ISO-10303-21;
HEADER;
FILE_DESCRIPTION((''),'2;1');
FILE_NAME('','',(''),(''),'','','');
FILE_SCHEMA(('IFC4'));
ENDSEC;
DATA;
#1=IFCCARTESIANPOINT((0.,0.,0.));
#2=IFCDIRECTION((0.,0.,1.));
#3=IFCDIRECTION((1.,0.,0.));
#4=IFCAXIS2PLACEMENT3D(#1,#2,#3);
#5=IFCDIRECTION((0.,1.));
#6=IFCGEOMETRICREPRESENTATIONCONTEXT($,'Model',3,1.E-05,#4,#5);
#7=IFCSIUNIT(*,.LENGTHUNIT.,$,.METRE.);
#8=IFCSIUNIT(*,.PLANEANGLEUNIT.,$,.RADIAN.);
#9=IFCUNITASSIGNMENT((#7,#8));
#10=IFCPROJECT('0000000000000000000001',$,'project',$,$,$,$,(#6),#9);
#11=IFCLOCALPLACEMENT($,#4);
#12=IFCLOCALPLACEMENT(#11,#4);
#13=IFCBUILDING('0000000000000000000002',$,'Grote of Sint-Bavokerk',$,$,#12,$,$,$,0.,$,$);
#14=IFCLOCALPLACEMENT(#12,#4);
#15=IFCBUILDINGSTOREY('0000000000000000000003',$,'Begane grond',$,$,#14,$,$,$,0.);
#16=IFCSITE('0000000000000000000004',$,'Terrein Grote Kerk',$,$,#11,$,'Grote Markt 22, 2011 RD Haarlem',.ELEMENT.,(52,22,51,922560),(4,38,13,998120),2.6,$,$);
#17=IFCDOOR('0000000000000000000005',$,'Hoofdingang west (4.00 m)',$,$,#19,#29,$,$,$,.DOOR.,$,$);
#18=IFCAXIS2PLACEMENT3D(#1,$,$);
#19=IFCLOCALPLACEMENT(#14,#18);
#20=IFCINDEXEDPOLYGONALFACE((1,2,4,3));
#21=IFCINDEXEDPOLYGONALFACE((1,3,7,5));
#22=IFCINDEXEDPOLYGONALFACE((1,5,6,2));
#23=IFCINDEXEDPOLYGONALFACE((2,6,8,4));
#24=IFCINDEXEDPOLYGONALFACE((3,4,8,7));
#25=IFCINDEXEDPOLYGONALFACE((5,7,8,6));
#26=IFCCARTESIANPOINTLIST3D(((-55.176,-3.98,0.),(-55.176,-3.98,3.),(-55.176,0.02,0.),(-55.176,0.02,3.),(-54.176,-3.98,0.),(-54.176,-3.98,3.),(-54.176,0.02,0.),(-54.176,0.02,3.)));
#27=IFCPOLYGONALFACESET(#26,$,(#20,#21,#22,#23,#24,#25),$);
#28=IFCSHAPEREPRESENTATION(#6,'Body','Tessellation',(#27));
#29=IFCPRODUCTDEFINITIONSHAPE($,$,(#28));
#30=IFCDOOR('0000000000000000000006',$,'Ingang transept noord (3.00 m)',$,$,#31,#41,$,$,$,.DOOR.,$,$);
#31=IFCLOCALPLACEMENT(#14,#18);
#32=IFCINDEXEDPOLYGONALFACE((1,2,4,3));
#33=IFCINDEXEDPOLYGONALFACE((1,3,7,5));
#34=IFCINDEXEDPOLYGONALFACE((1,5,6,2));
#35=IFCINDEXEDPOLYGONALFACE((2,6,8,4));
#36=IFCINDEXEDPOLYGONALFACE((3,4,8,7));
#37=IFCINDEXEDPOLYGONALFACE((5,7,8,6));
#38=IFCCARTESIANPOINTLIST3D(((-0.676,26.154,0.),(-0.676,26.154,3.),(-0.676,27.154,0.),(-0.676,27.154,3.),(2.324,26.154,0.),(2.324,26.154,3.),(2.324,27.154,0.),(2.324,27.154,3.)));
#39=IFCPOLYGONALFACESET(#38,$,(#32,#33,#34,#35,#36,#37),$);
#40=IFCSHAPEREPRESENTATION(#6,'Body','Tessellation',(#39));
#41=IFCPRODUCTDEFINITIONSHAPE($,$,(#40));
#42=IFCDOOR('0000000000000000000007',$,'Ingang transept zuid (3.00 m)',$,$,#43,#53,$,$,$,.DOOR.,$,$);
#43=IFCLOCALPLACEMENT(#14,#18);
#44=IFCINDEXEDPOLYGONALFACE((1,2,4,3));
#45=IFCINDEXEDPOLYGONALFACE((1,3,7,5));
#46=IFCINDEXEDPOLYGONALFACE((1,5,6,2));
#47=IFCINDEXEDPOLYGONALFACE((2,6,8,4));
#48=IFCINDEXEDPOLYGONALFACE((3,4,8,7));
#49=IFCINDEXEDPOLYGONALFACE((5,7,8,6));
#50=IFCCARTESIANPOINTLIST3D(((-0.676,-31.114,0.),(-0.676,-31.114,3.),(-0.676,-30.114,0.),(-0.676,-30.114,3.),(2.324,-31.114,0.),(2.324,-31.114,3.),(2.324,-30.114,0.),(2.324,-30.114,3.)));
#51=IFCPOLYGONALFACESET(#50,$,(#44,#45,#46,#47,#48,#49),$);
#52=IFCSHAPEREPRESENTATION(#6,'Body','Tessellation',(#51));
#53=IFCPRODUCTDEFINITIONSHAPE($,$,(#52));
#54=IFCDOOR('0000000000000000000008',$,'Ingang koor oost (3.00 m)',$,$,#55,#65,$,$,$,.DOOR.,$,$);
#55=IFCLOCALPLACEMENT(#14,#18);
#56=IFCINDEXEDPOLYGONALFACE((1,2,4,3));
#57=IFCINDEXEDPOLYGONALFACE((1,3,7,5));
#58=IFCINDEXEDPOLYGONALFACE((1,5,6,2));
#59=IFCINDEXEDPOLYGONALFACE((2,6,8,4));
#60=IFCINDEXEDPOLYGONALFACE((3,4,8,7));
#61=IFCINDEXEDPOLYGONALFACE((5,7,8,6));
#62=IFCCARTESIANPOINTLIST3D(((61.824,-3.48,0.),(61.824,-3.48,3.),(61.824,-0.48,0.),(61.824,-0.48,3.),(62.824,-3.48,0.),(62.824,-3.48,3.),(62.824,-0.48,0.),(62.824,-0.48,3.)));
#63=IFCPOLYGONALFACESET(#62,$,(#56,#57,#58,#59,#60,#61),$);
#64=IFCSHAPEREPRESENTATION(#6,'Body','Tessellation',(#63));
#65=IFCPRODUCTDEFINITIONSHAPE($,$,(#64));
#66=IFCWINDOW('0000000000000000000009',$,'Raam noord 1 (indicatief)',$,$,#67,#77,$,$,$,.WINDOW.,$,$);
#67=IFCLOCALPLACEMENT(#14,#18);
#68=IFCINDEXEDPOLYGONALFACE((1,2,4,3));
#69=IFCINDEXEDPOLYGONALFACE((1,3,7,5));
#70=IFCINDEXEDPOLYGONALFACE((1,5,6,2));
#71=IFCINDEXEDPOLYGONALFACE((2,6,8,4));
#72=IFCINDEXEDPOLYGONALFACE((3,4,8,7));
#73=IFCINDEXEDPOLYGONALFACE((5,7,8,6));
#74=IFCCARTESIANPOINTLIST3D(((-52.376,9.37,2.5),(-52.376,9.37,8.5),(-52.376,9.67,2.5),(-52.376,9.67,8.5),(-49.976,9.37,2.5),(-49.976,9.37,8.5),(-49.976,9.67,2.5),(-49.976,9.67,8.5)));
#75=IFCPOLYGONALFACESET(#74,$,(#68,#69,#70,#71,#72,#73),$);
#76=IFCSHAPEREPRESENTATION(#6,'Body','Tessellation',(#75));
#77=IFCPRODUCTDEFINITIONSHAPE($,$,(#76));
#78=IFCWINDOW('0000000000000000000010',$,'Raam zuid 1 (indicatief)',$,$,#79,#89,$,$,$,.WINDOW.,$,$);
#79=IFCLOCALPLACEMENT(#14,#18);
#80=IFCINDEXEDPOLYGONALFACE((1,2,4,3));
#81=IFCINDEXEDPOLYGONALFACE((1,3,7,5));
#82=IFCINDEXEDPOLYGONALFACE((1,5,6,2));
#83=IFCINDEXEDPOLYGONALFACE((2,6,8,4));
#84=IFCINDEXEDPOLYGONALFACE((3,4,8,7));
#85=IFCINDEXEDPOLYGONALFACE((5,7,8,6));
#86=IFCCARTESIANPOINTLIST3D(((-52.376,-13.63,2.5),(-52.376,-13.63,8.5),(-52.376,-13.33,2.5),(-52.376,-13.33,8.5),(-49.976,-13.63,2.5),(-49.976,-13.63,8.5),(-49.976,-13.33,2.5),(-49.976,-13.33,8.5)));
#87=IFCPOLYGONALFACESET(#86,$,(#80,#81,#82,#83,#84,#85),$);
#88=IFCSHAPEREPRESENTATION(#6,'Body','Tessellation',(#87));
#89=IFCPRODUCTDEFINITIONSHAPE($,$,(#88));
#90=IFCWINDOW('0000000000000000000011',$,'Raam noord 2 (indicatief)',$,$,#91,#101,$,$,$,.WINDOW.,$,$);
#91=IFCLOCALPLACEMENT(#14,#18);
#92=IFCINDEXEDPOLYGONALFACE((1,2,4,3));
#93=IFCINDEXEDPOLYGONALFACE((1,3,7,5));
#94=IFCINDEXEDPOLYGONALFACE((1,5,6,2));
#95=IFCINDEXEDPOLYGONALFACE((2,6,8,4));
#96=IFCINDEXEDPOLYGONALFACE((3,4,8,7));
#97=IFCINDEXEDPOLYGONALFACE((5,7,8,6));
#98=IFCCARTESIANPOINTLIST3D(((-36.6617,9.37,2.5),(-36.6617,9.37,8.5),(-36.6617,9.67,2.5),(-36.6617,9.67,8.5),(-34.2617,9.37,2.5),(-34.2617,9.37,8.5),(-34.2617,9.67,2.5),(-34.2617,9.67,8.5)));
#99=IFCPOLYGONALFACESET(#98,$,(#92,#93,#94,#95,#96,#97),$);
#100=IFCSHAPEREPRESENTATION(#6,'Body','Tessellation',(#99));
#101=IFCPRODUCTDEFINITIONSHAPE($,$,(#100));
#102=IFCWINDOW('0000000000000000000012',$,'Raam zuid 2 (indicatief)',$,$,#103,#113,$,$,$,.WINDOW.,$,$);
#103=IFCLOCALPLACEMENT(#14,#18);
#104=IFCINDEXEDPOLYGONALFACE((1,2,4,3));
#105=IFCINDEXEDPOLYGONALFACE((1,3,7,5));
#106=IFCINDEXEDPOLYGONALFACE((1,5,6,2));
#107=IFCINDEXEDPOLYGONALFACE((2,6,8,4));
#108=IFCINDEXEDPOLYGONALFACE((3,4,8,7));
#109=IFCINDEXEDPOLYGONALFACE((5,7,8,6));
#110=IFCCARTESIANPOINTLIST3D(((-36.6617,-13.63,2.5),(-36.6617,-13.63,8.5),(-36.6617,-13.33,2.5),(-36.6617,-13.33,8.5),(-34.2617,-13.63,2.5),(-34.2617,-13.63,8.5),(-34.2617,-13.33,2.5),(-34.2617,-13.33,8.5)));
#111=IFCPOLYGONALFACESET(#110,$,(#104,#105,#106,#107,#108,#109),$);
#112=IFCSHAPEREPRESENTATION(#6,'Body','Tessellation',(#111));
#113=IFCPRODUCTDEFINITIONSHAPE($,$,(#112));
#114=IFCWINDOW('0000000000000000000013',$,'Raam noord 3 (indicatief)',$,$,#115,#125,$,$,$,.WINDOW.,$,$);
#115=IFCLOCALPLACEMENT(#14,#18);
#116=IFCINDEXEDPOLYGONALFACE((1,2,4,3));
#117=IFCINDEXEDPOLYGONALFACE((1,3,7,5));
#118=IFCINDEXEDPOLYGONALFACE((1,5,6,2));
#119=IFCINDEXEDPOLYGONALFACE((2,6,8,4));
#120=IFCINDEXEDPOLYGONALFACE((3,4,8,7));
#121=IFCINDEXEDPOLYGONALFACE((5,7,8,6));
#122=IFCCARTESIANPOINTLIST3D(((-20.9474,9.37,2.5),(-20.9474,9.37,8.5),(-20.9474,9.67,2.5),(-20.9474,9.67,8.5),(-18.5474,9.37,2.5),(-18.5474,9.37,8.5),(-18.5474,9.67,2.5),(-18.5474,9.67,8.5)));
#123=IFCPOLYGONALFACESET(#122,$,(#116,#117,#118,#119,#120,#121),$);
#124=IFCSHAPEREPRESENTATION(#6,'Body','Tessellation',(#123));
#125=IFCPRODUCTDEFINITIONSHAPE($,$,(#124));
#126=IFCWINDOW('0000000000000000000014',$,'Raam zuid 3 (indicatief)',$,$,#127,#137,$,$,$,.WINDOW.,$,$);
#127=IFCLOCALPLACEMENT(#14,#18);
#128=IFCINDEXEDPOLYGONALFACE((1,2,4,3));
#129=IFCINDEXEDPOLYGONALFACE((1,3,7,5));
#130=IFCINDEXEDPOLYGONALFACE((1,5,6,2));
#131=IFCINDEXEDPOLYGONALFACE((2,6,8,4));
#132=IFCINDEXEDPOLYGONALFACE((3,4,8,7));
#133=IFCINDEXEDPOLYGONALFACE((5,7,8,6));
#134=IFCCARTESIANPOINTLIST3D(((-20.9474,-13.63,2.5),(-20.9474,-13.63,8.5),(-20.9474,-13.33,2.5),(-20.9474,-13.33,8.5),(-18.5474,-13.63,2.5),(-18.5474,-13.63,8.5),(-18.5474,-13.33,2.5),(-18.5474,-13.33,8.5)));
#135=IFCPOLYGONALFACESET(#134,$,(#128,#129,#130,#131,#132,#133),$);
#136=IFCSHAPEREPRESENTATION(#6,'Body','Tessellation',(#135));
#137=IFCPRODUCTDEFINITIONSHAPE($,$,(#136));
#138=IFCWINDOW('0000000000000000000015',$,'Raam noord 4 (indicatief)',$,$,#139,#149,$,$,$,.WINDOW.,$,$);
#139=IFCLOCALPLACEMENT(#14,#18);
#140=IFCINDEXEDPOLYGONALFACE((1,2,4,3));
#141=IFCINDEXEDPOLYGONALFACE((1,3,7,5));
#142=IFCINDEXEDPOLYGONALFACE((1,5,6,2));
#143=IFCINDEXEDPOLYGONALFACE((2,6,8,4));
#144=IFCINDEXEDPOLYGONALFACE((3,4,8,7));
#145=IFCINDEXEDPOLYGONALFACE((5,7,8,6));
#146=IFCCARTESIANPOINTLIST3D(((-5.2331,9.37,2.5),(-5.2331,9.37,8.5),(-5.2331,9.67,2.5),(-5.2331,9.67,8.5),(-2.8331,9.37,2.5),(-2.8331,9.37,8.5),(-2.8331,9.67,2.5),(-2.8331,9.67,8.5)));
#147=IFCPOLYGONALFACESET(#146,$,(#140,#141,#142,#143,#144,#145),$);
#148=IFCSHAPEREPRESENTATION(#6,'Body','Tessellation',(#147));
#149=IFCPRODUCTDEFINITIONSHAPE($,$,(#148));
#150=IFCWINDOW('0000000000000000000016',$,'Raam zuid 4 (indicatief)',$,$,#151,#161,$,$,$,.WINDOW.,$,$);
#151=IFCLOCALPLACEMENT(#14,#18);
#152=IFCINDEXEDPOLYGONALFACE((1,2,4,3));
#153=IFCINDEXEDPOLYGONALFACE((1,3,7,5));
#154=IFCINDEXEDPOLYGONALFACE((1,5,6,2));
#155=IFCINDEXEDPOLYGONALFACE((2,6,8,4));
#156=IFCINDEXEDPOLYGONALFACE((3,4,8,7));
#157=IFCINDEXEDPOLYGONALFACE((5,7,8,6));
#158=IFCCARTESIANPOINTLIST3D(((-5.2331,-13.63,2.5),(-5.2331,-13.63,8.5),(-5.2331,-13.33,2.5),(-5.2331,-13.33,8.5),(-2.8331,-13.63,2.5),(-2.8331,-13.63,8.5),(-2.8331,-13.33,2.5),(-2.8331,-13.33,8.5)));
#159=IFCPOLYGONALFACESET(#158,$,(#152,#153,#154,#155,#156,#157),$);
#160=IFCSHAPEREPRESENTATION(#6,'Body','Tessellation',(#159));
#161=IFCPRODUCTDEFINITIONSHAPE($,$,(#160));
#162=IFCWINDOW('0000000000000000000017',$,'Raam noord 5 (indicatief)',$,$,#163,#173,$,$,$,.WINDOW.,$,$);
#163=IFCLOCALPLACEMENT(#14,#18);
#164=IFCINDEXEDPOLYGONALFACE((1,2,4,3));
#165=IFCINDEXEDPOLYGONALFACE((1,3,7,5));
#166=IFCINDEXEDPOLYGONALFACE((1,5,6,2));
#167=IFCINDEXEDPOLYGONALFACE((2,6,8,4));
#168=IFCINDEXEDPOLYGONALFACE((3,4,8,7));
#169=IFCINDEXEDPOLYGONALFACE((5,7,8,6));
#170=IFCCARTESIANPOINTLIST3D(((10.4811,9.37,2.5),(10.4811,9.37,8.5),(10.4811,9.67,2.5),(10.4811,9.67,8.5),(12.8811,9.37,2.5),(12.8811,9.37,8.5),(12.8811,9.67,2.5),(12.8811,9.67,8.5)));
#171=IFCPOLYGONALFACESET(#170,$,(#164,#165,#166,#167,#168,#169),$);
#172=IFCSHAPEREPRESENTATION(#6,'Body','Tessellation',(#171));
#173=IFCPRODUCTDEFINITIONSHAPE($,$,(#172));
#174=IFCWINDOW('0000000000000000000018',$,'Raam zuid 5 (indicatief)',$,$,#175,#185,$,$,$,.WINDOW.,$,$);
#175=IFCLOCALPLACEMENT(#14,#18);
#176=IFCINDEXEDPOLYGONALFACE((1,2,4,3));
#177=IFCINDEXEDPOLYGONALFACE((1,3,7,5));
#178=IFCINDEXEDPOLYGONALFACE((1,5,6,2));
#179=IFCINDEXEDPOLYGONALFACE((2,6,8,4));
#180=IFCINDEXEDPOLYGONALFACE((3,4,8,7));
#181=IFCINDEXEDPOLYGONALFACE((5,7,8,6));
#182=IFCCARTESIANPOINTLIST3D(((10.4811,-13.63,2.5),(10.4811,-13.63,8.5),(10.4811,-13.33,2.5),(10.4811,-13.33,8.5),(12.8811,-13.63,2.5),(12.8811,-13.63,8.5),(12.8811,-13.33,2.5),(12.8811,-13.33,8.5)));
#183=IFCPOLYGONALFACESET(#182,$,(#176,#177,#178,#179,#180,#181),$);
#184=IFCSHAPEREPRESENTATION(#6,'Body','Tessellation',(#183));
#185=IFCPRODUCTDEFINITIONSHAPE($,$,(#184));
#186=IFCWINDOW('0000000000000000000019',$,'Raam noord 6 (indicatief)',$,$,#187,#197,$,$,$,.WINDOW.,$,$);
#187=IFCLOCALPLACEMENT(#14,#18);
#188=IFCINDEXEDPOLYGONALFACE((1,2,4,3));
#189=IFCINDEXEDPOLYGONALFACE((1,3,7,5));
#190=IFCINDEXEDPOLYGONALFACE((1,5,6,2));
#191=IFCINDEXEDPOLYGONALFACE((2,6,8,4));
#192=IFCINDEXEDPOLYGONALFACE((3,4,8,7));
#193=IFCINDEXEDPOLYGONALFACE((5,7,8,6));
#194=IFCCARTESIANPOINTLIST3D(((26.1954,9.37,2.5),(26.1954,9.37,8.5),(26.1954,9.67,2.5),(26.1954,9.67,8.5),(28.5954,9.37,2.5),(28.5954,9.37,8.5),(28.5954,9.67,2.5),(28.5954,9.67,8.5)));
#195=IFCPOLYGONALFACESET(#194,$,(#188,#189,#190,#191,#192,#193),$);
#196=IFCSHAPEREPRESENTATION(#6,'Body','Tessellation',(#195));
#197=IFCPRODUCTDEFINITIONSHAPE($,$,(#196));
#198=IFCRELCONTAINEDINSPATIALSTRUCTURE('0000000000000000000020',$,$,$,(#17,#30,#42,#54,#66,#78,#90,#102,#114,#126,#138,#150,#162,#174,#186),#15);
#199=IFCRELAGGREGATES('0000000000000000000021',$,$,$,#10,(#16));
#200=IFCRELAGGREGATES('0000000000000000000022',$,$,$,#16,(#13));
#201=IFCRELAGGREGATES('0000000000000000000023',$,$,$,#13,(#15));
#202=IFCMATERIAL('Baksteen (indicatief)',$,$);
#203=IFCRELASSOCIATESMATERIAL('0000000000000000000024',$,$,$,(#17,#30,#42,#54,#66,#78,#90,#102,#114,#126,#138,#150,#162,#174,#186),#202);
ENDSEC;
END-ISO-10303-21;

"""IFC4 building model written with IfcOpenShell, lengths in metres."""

from ifc_helpers import new_model, si_unit, direction, frame, origin_with_axes, place, context, project, spatial, indexed_curve, outline, extrude, material, element, save


model = new_model("IFC4")

# Units and contexts
model_context = context("Model", 3, precision=1e-05, world=origin_with_axes(), true_north=direction((0.0, 1.0)))
ifc_project = project(units=[si_unit("LENGTHUNIT", "METRE"), si_unit("PLANEANGLEUNIT", "RADIAN")], contexts=[model_context])

# Site, building, storey
site_placement = place(None, origin_with_axes())
site = spatial("IfcSite", under=ifc_project, at=site_placement, Name="Terrein Grote Kerk", LongName="Grote Markt 22, 2011 RD Haarlem", CompositionType="ELEMENT", RefLatitude=(52, 22, 51, 922560), RefLongitude=(4, 38, 13, 998120), RefElevation=2.6)
building_placement = place(site_placement, origin_with_axes())
building = spatial("IfcBuilding", under=site, at=building_placement, Name="Grote of Sint-Bavokerk", ElevationOfRefHeight=0.0)
storey_placement = place(building_placement, origin_with_axes())
storey = spatial("IfcBuildingStorey", under=building, at=storey_placement, Name="Begane grond", Elevation=0.0)

# Doors
ifc_material = material(Name="Baksteen (indicatief)")
door_1_placement = place(storey_placement, origin_with_axes())
element("IfcDoor", 1, at=door_1_placement, inside=storey, material=ifc_material, Name="Hoofdingang west (4.00 m)", PredefinedType="DOOR", context=model_context, shape_type="SweptSolid", body=[
    extrude(outline(indexed_curve([(-55.176, -3.98), (-54.176, -3.98), (-54.176, 0.02), (-55.176, 0.02), (-55.176, -3.98)])), origin_with_axes(), (0.0, 0.0, 1.0), 3.0),
])
door_2_placement = place(storey_placement, origin_with_axes())
element("IfcDoor", 2, at=door_2_placement, inside=storey, material=ifc_material, Name="Ingang transept noord (3.00 m)", PredefinedType="DOOR", context=model_context, shape_type="SweptSolid", body=[
    extrude(outline(indexed_curve([(-0.676, 26.154), (2.324, 26.154), (2.324, 27.154), (-0.676, 27.154), (-0.676, 26.154)])), origin_with_axes(), (0.0, 0.0, 1.0), 3.0),
])
door_3_placement = place(storey_placement, origin_with_axes())
element("IfcDoor", 3, at=door_3_placement, inside=storey, material=ifc_material, Name="Ingang transept zuid (3.00 m)", PredefinedType="DOOR", context=model_context, shape_type="SweptSolid", body=[
    extrude(outline(indexed_curve([(-0.676, -31.114), (2.324, -31.114), (2.324, -30.114), (-0.676, -30.114), (-0.676, -31.114)])), origin_with_axes(), (0.0, 0.0, 1.0), 3.0),
])
door_4_placement = place(storey_placement, origin_with_axes())
element("IfcDoor", 4, at=door_4_placement, inside=storey, material=ifc_material, Name="Ingang koor oost (3.00 m)", PredefinedType="DOOR", context=model_context, shape_type="SweptSolid", body=[
    extrude(outline(indexed_curve([(61.824, -3.48), (62.824, -3.48), (62.824, -0.48), (61.824, -0.48), (61.824, -3.48)])), origin_with_axes(), (0.0, 0.0, 1.0), 3.0),
])

# Windows
window_1_placement = place(storey_placement, origin_with_axes())
element("IfcWindow", 5, at=window_1_placement, inside=storey, material=ifc_material, Name="Raam noord 1 (indicatief)", PredefinedType="WINDOW", context=model_context, shape_type="SweptSolid", body=[
    extrude(outline(indexed_curve([(-52.376, 9.37), (-49.976, 9.37), (-49.976, 9.67), (-52.376, 9.67), (-52.376, 9.37)])), frame((0.0, 0.0, 2.5), z_axis=(0.0, 0.0, 1.0), x_axis=(1.0, 0.0, 0.0)), (0.0, 0.0, 1.0), 6.0),
])
window_2_placement = place(storey_placement, origin_with_axes())
element("IfcWindow", 6, at=window_2_placement, inside=storey, material=ifc_material, Name="Raam zuid 1 (indicatief)", PredefinedType="WINDOW", context=model_context, shape_type="SweptSolid", body=[
    extrude(outline(indexed_curve([(-52.376, -13.63), (-49.976, -13.63), (-49.976, -13.33), (-52.376, -13.33), (-52.376, -13.63)])), frame((0.0, 0.0, 2.5), z_axis=(0.0, 0.0, 1.0), x_axis=(1.0, 0.0, 0.0)), (0.0, 0.0, 1.0), 6.0),
])
window_3_placement = place(storey_placement, origin_with_axes())
element("IfcWindow", 7, at=window_3_placement, inside=storey, material=ifc_material, Name="Raam noord 2 (indicatief)", PredefinedType="WINDOW", context=model_context, shape_type="SweptSolid", body=[
    extrude(outline(indexed_curve([(-36.6617, 9.37), (-34.2617, 9.37), (-34.2617, 9.67), (-36.6617, 9.67), (-36.6617, 9.37)])), frame((0.0, 0.0, 2.5), z_axis=(0.0, 0.0, 1.0), x_axis=(1.0, 0.0, 0.0)), (0.0, 0.0, 1.0), 6.0),
])
window_4_placement = place(storey_placement, origin_with_axes())
element("IfcWindow", 8, at=window_4_placement, inside=storey, material=ifc_material, Name="Raam zuid 2 (indicatief)", PredefinedType="WINDOW", context=model_context, shape_type="SweptSolid", body=[
    extrude(outline(indexed_curve([(-36.6617, -13.63), (-34.2617, -13.63), (-34.2617, -13.33), (-36.6617, -13.33), (-36.6617, -13.63)])), frame((0.0, 0.0, 2.5), z_axis=(0.0, 0.0, 1.0), x_axis=(1.0, 0.0, 0.0)), (0.0, 0.0, 1.0), 6.0),
])
window_5_placement = place(storey_placement, origin_with_axes())
element("IfcWindow", 9, at=window_5_placement, inside=storey, material=ifc_material, Name="Raam noord 3 (indicatief)", PredefinedType="WINDOW", context=model_context, shape_type="SweptSolid", body=[
    extrude(outline(indexed_curve([(-20.9474, 9.37), (-18.5474, 9.37), (-18.5474, 9.67), (-20.9474, 9.67), (-20.9474, 9.37)])), frame((0.0, 0.0, 2.5), z_axis=(0.0, 0.0, 1.0), x_axis=(1.0, 0.0, 0.0)), (0.0, 0.0, 1.0), 6.0),
])
window_6_placement = place(storey_placement, origin_with_axes())
element("IfcWindow", 10, at=window_6_placement, inside=storey, material=ifc_material, Name="Raam zuid 3 (indicatief)", PredefinedType="WINDOW", context=model_context, shape_type="SweptSolid", body=[
    extrude(outline(indexed_curve([(-20.9474, -13.63), (-18.5474, -13.63), (-18.5474, -13.33), (-20.9474, -13.33), (-20.9474, -13.63)])), frame((0.0, 0.0, 2.5), z_axis=(0.0, 0.0, 1.0), x_axis=(1.0, 0.0, 0.0)), (0.0, 0.0, 1.0), 6.0),
])
window_7_placement = place(storey_placement, origin_with_axes())
element("IfcWindow", 11, at=window_7_placement, inside=storey, material=ifc_material, Name="Raam noord 4 (indicatief)", PredefinedType="WINDOW", context=model_context, shape_type="SweptSolid", body=[
    extrude(outline(indexed_curve([(-5.2331, 9.37), (-2.8331, 9.37), (-2.8331, 9.67), (-5.2331, 9.67), (-5.2331, 9.37)])), frame((0.0, 0.0, 2.5), z_axis=(0.0, 0.0, 1.0), x_axis=(1.0, 0.0, 0.0)), (0.0, 0.0, 1.0), 6.0),
])
window_8_placement = place(storey_placement, origin_with_axes())
element("IfcWindow", 12, at=window_8_placement, inside=storey, material=ifc_material, Name="Raam zuid 4 (indicatief)", PredefinedType="WINDOW", context=model_context, shape_type="SweptSolid", body=[
    extrude(outline(indexed_curve([(-5.2331, -13.63), (-2.8331, -13.63), (-2.8331, -13.33), (-5.2331, -13.33), (-5.2331, -13.63)])), frame((0.0, 0.0, 2.5), z_axis=(0.0, 0.0, 1.0), x_axis=(1.0, 0.0, 0.0)), (0.0, 0.0, 1.0), 6.0),
])
window_9_placement = place(storey_placement, origin_with_axes())
element("IfcWindow", 13, at=window_9_placement, inside=storey, material=ifc_material, Name="Raam noord 5 (indicatief)", PredefinedType="WINDOW", context=model_context, shape_type="SweptSolid", body=[
    extrude(outline(indexed_curve([(10.4811, 9.37), (12.8811, 9.37), (12.8811, 9.67), (10.4811, 9.67), (10.4811, 9.37)])), frame((0.0, 0.0, 2.5), z_axis=(0.0, 0.0, 1.0), x_axis=(1.0, 0.0, 0.0)), (0.0, 0.0, 1.0), 6.0),
])
window_10_placement = place(storey_placement, origin_with_axes())
element("IfcWindow", 14, at=window_10_placement, inside=storey, material=ifc_material, Name="Raam zuid 5 (indicatief)", PredefinedType="WINDOW", context=model_context, shape_type="SweptSolid", body=[
    extrude(outline(indexed_curve([(10.4811, -13.63), (12.8811, -13.63), (12.8811, -13.33), (10.4811, -13.33), (10.4811, -13.63)])), frame((0.0, 0.0, 2.5), z_axis=(0.0, 0.0, 1.0), x_axis=(1.0, 0.0, 0.0)), (0.0, 0.0, 1.0), 6.0),
])
window_11_placement = place(storey_placement, origin_with_axes())
element("IfcWindow", 15, at=window_11_placement, inside=storey, material=ifc_material, Name="Raam noord 6 (indicatief)", PredefinedType="WINDOW", context=model_context, shape_type="SweptSolid", body=[
    extrude(outline(indexed_curve([(26.1954, 9.37), (28.5954, 9.37), (28.5954, 9.67), (26.1954, 9.67), (26.1954, 9.37)])), frame((0.0, 0.0, 2.5), z_axis=(0.0, 0.0, 1.0), x_axis=(1.0, 0.0, 0.0)), (0.0, 0.0, 1.0), 6.0),
])

save(model, "model.ifc")
